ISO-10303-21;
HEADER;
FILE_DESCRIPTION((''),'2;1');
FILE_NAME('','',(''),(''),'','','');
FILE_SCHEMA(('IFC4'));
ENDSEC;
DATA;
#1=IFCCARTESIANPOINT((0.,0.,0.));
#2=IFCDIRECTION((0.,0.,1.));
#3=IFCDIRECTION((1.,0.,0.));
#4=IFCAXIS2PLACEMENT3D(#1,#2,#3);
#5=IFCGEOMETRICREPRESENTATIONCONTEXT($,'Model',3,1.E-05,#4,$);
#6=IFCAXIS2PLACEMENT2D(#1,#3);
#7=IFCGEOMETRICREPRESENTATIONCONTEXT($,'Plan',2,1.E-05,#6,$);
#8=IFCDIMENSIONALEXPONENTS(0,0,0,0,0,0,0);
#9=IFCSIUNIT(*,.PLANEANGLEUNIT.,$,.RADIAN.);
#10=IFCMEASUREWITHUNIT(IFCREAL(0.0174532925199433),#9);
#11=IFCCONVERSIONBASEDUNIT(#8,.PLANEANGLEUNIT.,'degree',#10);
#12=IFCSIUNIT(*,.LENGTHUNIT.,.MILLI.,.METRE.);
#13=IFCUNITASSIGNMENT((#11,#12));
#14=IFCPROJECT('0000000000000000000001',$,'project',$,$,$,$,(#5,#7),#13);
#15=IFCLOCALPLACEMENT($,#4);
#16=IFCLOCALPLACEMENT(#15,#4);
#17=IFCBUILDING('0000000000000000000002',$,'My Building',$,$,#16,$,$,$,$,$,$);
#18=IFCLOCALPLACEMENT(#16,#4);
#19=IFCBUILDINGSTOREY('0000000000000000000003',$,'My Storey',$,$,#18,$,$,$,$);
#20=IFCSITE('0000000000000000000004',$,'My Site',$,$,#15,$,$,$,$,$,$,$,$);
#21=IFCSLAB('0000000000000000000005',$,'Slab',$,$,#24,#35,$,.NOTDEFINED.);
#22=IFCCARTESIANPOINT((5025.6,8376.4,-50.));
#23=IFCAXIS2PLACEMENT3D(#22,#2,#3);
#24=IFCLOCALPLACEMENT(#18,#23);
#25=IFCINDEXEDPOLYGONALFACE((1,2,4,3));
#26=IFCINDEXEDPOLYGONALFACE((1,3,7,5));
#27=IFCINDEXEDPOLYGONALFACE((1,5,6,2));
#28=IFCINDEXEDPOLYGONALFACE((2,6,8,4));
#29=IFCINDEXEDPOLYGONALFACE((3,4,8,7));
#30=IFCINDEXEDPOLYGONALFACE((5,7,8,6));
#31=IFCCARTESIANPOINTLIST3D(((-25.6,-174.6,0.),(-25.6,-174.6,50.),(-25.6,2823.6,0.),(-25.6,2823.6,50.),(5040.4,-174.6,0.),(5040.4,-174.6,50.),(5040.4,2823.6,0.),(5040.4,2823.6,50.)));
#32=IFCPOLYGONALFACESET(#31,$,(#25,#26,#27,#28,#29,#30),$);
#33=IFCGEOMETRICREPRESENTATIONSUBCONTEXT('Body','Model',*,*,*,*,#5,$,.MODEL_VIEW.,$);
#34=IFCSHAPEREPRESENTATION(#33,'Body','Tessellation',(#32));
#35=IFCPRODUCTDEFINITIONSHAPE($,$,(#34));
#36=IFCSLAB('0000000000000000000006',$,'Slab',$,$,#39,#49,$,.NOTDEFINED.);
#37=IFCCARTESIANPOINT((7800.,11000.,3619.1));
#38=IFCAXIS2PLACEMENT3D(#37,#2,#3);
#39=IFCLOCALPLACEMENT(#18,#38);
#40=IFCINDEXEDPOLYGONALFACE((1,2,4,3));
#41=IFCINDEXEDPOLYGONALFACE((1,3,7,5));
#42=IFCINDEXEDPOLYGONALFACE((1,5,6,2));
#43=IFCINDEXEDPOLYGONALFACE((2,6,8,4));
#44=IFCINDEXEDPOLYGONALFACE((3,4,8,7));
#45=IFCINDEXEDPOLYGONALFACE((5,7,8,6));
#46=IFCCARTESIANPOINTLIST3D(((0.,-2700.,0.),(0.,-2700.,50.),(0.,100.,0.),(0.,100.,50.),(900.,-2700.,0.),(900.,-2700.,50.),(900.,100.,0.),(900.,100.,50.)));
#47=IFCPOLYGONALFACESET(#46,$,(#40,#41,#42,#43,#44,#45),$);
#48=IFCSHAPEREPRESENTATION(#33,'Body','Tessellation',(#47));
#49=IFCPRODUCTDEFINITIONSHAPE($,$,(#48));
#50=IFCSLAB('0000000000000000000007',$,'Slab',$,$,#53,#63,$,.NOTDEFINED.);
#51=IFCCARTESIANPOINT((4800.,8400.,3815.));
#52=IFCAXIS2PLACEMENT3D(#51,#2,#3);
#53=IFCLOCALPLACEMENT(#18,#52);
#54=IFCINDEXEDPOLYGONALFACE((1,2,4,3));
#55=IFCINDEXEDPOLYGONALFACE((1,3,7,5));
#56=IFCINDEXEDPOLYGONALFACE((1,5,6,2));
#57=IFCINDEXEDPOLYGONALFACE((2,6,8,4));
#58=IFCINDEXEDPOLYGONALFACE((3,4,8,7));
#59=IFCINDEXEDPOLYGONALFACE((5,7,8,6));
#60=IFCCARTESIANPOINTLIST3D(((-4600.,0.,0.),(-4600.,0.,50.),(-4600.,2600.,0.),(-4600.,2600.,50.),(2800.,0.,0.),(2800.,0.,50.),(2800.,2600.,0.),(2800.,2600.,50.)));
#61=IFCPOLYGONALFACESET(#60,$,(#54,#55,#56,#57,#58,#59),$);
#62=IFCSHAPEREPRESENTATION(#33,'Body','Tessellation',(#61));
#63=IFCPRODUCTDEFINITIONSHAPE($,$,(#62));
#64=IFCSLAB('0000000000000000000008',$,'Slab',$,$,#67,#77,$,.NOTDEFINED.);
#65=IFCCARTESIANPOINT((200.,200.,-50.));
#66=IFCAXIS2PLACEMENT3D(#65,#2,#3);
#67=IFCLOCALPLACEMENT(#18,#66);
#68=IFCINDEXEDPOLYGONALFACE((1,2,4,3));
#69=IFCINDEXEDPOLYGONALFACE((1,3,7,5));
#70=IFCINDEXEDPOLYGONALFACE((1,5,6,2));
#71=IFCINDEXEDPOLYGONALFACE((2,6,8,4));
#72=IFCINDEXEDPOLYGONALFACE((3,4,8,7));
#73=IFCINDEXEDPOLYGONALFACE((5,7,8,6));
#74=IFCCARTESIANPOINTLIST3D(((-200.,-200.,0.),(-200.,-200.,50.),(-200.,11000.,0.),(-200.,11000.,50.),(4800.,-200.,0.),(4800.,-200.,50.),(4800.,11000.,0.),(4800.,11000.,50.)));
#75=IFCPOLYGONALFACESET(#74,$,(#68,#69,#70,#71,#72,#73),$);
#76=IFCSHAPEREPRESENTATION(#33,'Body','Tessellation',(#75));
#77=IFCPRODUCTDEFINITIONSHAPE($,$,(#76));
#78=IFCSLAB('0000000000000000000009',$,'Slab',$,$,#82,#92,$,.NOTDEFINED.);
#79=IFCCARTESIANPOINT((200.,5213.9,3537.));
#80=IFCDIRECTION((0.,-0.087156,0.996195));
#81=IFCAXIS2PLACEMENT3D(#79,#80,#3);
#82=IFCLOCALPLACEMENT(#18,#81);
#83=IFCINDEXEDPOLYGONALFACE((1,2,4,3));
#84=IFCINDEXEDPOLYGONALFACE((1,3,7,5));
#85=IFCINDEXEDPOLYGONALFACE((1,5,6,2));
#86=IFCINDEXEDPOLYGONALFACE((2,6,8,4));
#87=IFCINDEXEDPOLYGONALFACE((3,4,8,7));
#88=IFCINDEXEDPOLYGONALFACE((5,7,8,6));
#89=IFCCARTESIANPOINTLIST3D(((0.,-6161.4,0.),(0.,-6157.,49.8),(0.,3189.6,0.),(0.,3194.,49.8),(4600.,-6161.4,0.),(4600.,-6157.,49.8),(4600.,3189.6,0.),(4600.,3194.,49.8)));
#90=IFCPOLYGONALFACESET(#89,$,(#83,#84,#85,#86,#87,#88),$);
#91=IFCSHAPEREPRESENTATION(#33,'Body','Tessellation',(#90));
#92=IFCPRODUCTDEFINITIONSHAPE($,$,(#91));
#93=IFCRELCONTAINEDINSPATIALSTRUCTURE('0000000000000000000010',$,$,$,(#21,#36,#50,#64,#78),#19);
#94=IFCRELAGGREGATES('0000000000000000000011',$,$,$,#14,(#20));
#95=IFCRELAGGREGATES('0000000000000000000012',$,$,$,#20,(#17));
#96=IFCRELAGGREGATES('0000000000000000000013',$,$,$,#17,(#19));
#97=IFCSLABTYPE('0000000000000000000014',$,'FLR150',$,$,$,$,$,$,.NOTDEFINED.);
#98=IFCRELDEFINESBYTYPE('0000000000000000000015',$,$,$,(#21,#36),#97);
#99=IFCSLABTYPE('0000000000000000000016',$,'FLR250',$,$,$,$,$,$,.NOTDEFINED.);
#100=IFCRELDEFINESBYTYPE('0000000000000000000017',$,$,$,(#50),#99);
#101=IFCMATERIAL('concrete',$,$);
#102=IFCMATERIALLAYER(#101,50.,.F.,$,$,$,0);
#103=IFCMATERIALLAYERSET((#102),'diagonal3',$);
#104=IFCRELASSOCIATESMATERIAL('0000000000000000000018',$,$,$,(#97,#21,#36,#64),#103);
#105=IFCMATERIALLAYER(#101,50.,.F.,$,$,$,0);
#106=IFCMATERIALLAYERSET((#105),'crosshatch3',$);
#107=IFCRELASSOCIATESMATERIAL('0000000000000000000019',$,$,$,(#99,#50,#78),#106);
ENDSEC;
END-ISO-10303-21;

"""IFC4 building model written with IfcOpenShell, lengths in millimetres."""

from ifc_helpers import new_model, entity, si_unit, converted_unit, frame, frame_2d, origin_with_axes, place, context, subcontext, project, spatial, line, indexed_curve, outline, extrude, material, layer, layer_set, layer_usage, type_object, element, save


model = new_model("IFC4")

# Units and contexts
model_context = context("Model", 3, precision=1e-05, world=origin_with_axes())
plan_context = context("Plan", 2, precision=1e-05, world=frame_2d((0.0, 0.0, 0.0), x_axis=(1.0, 0.0, 0.0)))
body_context = subcontext(model_context, "Body", "Model", "MODEL_VIEW")
ifc_project = project(units=[converted_unit("PLANEANGLEUNIT", "degree", entity("IfcReal", 0.0174532925199433), si_unit("PLANEANGLEUNIT", "RADIAN"), dimensions=[0, 0, 0, 0, 0, 0, 0]), si_unit("LENGTHUNIT", "METRE", prefix="MILLI")], contexts=[model_context, plan_context])

# Site, building, storey
site_placement = place(None, origin_with_axes())
site = spatial("IfcSite", under=ifc_project, at=site_placement, Name="My Site")
building_placement = place(site_placement, origin_with_axes())
building = spatial("IfcBuilding", under=site, at=building_placement, Name="My Building")
storey_placement = place(building_placement, origin_with_axes())
storey = spatial("IfcBuildingStorey", under=building, at=storey_placement, Name="My Storey")

# Shared definitions
ifc_material = material(Name="concrete")

# Slabs
ifc_layer_1 = layer(ifc_material, 50.0, ventilated=False, Priority=0)
ifc_layer_set_1 = layer_set([ifc_layer_1], Name="diagonal3")
ifc_layer_usage_1 = layer_usage(ifc_layer_set_1, "AXIS3", "POSITIVE", 0.0)
slab_type_1 = type_object("IfcSlabType", Name="FLR150", PredefinedType="NOTDEFINED", material=ifc_layer_set_1)
slab_1_placement = place(storey_placement, frame((5025.6, 8376.4, -50.0), z_axis=(0.0, 0.0, 1.0), x_axis=(1.0, 0.0, 0.0)))
element("IfcSlab", 1, at=slab_1_placement, inside=storey, type_object=slab_type_1, material=ifc_layer_usage_1, Name="Slab", PredefinedType="NOTDEFINED", context=body_context, shape_type="SweptSolid", body=[
    extrude(outline(indexed_curve([(5040.4, -174.6), (5040.4, 2823.6), (-25.6, 2823.6), (-25.6, -174.6)], segments=[line(3, 2), line(2, 1), line(1, 4), line(4, 3)], self_intersect=False)), None, (0.0, 0.0, 1.0), 50.0),
])
ifc_layer_usage_2 = layer_usage(ifc_layer_set_1, "AXIS3", "POSITIVE", 0.0)
slab_2_placement = place(storey_placement, frame((7800.0, 11000.0, 3619.1), z_axis=(0.0, 0.0, 1.0), x_axis=(1.0, 0.0, 0.0)))
element("IfcSlab", 2, at=slab_2_placement, inside=storey, type_object=slab_type_1, material=ifc_layer_usage_2, Name="Slab", PredefinedType="NOTDEFINED", context=body_context, shape_type="SweptSolid", body=[
    extrude(outline(indexed_curve([(0.0, -2700.0), (900.0, -2700.0), (900.0, 100.0), (0.0, 100.0)], segments=[line(3, 2), line(2, 1), line(1, 4), line(4, 3)], self_intersect=False)), None, (0.0, 0.0, 1.0), 50.0),
])
ifc_layer_2 = layer(ifc_material, 50.0, ventilated=False, Priority=0)
ifc_layer_set_2 = layer_set([ifc_layer_2], Name="crosshatch3")
ifc_layer_usage_3 = layer_usage(ifc_layer_set_2, "AXIS3", "POSITIVE", 0.0)
slab_type_2 = type_object("IfcSlabType", Name="FLR250", PredefinedType="NOTDEFINED", material=ifc_layer_set_2)
slab_3_placement = place(storey_placement, frame((4800.0, 8400.0, 3815.0), z_axis=(0.0, 0.0, 1.0), x_axis=(1.0, 0.0, 0.0)))
element("IfcSlab", 3, at=slab_3_placement, inside=storey, type_object=slab_type_2, material=ifc_layer_usage_3, Name="Slab", PredefinedType="NOTDEFINED", context=body_context, shape_type="SweptSolid", body=[
    extrude(outline(indexed_curve([(-4600.0, 0.0), (2800.0, 0.0), (2800.0, 2600.0), (-4600.0, 2600.0)], segments=[line(4, 1), line(1, 2), line(2, 3), line(3, 4)], self_intersect=False)), None, (0.0, 0.0, 1.0), 50.0),
])
ifc_layer_usage_4 = layer_usage(ifc_layer_set_1, "AXIS3", "POSITIVE", 0.0)
slab_4_placement = place(storey_placement, frame((200.0, 200.0, -50.0), z_axis=(0.0, 0.0, 1.0), x_axis=(1.0, 0.0, 0.0)))
element("IfcSlab", 4, at=slab_4_placement, inside=storey, material=ifc_layer_usage_4, Name="Slab", PredefinedType="NOTDEFINED", context=body_context, shape_type="SweptSolid", body=[
    extrude(outline(indexed_curve([(-200.0, -200.0), (-200.0, 11000.0), (4800.0, 11000.0), (4800.0, -200.0)], segments=[line(3, 2), line(2, 1), line(1, 4), line(4, 3)], self_intersect=False)), None, (0.0, 0.0, 1.0), 50.0),
])
ifc_layer_usage_5 = layer_usage(ifc_layer_set_2, "AXIS3", "POSITIVE", 0.0)
slab_5_placement = place(storey_placement, frame((200.0, 5213.9, 3537.0), z_axis=(0.0, -0.087156, 0.996195), x_axis=(1.0, 0.0, 0.0)))
element("IfcSlab", 5, at=slab_5_placement, inside=storey, material=ifc_layer_usage_5, Name="Slab", PredefinedType="NOTDEFINED", context=body_context, shape_type="SweptSolid", body=[
    extrude(outline(indexed_curve([(0.0, -6161.4), (4600.0, -6161.4), (4600.0, 3189.6), (0.0, 3189.6)], segments=[line(3, 2), line(2, 1), line(1, 4), line(4, 3)], self_intersect=False)), None, (0.0, 0.087156, 0.996195), 50.0),
])

save(model, "model.ifc")
